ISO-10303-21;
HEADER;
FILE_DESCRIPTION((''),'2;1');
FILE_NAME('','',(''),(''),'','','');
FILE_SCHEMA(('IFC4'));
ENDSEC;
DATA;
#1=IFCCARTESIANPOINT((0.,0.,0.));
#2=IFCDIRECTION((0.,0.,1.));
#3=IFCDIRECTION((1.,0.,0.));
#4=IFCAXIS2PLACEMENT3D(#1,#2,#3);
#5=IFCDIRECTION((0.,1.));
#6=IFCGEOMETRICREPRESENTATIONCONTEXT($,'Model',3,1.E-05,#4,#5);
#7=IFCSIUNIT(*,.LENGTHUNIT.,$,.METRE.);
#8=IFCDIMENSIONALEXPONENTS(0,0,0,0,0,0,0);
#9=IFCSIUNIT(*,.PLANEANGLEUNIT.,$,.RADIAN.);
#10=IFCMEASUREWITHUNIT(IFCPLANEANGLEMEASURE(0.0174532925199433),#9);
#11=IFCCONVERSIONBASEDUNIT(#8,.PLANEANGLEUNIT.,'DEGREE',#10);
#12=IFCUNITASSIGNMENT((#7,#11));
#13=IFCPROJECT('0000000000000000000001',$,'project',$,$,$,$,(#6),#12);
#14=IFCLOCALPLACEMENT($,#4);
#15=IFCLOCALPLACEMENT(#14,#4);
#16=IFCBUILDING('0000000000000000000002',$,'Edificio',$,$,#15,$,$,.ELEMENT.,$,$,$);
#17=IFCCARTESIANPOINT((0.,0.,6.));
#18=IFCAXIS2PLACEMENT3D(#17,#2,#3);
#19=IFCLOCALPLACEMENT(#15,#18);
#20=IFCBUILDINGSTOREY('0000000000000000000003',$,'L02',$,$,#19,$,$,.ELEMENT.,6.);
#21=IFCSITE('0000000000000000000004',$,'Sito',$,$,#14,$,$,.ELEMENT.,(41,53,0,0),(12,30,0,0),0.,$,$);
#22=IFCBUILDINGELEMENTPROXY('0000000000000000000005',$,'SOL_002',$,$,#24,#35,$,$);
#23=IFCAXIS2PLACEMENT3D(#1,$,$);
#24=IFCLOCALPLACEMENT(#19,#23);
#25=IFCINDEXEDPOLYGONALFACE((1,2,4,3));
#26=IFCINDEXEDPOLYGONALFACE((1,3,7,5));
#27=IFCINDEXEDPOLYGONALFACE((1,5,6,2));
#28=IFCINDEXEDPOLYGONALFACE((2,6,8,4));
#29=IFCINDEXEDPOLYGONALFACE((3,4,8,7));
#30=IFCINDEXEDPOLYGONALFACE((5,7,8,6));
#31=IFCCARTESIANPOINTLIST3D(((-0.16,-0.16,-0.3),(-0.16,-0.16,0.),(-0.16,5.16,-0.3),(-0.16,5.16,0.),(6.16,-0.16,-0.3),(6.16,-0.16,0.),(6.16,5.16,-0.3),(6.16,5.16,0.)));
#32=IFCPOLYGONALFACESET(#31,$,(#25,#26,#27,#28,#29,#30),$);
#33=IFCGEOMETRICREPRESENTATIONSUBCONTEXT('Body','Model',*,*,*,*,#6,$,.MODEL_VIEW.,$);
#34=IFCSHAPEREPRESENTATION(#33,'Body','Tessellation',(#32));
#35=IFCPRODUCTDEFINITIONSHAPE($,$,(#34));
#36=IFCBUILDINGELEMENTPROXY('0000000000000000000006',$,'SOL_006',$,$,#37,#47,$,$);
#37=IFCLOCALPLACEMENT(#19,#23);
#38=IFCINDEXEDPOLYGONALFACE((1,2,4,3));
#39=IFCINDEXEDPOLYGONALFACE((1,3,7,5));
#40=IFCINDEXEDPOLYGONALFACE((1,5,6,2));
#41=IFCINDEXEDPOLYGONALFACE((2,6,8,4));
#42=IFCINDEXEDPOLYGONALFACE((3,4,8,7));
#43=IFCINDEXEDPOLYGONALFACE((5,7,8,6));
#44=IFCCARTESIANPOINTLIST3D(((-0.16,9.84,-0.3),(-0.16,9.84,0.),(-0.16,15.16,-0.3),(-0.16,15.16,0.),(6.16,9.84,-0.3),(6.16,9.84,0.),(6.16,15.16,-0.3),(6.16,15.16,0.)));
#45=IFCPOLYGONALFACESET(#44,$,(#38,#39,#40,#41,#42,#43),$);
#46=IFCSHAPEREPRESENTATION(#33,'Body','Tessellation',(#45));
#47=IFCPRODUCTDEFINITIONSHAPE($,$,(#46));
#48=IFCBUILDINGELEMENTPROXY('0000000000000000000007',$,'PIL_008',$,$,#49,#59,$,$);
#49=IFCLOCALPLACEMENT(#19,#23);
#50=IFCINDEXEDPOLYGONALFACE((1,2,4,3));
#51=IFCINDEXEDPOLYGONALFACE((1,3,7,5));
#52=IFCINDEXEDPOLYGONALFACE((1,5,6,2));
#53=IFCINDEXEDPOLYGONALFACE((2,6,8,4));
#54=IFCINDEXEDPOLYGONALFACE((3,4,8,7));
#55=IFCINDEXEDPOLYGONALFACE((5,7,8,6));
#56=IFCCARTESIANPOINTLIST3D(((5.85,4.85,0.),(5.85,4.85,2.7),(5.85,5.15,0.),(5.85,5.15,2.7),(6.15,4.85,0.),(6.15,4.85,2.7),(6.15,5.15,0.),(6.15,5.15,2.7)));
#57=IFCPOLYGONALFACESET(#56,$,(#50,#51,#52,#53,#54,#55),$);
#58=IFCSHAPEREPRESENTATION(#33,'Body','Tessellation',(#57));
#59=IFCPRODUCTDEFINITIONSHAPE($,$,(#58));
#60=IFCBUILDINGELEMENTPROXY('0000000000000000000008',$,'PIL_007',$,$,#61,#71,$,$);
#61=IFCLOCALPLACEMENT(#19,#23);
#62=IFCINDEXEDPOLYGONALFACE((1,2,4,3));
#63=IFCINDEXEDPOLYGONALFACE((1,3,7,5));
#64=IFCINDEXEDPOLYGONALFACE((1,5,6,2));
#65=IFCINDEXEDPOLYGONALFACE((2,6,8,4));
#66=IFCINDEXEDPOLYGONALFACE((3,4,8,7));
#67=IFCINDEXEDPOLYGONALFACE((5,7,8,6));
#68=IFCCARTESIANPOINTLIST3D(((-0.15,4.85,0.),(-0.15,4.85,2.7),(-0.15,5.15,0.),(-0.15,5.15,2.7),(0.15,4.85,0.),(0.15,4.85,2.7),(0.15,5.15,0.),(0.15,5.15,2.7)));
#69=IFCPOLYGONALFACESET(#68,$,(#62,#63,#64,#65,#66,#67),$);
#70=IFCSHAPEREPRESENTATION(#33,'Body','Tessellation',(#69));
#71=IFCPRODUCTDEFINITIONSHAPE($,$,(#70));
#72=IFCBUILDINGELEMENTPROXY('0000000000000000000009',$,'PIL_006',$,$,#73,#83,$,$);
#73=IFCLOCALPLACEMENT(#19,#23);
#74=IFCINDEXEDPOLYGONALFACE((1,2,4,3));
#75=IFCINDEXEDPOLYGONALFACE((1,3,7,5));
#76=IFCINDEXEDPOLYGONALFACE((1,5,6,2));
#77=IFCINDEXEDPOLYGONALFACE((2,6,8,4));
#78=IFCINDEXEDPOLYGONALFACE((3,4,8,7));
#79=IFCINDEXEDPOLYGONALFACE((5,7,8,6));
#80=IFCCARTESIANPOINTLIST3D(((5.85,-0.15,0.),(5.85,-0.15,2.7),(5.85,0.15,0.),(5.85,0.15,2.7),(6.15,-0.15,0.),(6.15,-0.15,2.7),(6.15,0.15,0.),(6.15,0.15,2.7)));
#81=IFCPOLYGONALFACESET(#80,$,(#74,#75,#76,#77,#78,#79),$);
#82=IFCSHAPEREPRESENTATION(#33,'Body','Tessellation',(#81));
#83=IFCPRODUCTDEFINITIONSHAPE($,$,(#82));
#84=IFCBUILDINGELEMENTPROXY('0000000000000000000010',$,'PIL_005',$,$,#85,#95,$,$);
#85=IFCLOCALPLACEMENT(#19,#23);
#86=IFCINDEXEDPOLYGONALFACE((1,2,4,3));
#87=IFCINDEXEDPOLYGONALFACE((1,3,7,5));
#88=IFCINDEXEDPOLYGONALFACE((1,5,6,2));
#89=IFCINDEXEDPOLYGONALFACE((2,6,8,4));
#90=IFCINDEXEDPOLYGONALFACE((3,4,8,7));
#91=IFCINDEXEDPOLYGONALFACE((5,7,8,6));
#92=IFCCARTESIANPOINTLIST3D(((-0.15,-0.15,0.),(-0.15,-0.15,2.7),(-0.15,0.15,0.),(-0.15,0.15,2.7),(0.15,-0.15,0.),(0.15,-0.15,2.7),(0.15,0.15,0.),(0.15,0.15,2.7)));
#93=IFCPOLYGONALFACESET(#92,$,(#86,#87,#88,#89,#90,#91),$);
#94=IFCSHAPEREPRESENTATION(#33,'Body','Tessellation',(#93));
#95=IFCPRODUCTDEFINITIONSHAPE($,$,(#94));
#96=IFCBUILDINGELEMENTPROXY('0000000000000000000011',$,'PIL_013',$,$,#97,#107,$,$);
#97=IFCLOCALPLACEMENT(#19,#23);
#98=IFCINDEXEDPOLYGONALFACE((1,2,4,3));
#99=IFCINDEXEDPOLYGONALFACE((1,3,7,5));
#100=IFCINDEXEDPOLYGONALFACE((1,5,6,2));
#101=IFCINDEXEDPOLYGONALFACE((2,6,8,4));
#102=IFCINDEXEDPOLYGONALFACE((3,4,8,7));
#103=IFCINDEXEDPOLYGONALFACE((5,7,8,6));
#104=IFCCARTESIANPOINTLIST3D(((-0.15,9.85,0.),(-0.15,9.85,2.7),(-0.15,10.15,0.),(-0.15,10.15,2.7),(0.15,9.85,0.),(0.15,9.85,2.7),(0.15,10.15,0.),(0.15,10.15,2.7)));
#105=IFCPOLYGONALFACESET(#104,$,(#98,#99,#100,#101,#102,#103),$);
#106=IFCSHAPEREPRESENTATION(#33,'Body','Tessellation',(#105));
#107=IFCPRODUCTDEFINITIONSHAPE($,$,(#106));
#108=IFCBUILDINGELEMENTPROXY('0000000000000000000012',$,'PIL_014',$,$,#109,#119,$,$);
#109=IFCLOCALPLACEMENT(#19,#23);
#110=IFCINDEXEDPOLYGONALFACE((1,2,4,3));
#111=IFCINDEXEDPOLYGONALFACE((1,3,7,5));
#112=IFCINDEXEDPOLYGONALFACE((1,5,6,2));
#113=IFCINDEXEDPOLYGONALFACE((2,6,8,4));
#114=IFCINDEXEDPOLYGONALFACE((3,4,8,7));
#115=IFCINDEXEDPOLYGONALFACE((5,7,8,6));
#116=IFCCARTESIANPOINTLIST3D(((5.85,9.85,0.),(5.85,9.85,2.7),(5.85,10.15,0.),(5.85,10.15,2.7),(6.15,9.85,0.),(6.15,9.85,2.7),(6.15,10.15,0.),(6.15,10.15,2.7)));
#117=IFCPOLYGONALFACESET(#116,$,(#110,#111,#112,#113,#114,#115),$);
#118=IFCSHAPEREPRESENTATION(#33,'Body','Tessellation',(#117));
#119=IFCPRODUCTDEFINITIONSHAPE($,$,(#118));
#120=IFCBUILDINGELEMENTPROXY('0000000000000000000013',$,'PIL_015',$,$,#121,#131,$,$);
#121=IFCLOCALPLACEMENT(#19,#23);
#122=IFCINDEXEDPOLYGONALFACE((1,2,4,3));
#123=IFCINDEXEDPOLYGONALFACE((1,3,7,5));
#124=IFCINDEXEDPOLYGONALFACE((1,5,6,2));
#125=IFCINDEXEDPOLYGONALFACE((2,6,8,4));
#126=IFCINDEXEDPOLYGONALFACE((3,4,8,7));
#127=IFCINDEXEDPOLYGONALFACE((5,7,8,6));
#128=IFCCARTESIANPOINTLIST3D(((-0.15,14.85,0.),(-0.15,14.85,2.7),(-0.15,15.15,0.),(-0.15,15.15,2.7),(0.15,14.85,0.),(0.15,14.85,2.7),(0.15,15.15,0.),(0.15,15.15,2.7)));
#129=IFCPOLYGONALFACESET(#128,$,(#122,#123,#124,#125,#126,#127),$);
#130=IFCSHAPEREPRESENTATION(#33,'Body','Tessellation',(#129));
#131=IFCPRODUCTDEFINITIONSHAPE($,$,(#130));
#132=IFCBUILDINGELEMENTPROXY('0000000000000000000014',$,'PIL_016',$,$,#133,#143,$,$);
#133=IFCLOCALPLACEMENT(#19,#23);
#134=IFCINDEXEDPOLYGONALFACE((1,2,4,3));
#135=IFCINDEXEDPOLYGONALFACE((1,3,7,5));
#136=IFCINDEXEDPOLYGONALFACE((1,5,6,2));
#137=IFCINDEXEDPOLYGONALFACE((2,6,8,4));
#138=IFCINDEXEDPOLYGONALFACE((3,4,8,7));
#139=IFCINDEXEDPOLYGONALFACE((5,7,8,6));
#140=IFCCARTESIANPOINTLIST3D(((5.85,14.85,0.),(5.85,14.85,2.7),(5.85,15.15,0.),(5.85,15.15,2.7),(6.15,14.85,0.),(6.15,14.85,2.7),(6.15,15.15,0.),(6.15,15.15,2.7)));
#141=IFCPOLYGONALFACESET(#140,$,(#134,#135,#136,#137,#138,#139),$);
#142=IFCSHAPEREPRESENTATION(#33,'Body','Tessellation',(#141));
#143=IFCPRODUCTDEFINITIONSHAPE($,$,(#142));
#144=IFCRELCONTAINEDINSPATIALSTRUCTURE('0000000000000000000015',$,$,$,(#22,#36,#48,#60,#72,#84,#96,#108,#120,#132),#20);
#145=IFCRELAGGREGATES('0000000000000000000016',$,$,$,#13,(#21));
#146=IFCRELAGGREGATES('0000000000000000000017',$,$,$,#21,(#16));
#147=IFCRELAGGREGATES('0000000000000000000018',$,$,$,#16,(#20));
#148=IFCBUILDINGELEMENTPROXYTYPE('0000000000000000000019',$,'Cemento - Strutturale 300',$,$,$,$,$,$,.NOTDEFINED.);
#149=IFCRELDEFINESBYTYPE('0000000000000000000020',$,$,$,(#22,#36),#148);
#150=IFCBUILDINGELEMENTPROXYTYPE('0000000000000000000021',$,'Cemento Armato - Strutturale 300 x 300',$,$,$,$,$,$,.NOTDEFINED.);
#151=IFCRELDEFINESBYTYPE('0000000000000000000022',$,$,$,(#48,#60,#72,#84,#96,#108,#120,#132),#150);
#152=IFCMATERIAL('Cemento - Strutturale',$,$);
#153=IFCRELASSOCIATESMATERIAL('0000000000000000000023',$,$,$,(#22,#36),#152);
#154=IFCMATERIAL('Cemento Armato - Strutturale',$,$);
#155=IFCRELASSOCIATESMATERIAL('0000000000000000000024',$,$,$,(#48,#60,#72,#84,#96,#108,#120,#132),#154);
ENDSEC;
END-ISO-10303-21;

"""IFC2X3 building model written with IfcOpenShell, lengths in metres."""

from ifc_helpers import new_model, entity, si_unit, converted_unit, direction, frame, origin_with_axes, origin_2d_with_axis, place, context, subcontext, project, spatial, polyline, rectangle, outline, extrude, material, type_object, element, save


model = new_model("IFC2X3")

# Units and contexts
model_context = context("Model", 3, precision=1e-05, world=origin_with_axes(), true_north=direction((0.0, 1.0)))
body_context = subcontext(model_context, "Body", "Model", "MODEL_VIEW")
ifc_project = project(units=[si_unit("LENGTHUNIT", "METRE"), converted_unit("PLANEANGLEUNIT", "DEGREE", entity("IfcPlaneAngleMeasure", 0.0174532925199433), si_unit("PLANEANGLEUNIT", "RADIAN"), dimensions=[0, 0, 0, 0, 0, 0, 0])], contexts=[model_context])

# Site, building, storey
site_placement = place(None, origin_with_axes())
site = spatial("IfcSite", under=ifc_project, at=site_placement, Name="Sito", CompositionType="ELEMENT", RefLatitude=(41, 53, 0, 0), RefLongitude=(12, 30, 0, 0), RefElevation=0.0)
building_placement = place(site_placement, origin_with_axes())
building = spatial("IfcBuilding", under=site, at=building_placement, Name="Edificio", CompositionType="ELEMENT")
storey_placement = place(building_placement, frame((0.0, 0.0, 6.0), z_axis=(0.0, 0.0, 1.0), x_axis=(1.0, 0.0, 0.0)))
storey = spatial("IfcBuildingStorey", under=building, at=storey_placement, Name="L02", CompositionType="ELEMENT", Elevation=6.0)

# Building element proxies
ifc_material_1 = material(Name="Cemento - Strutturale")
building_element_proxy_type_1 = type_object("IfcBuildingElementProxyType", Name="Cemento - Strutturale 300", PredefinedType="NOTDEFINED")
for number, where, z_axis, x_axis, name in (
    (1, (-0.16, -0.16, 0.0), (0.0, 0.0, 1.0), (1.0, 0.0, 0.0), "SOL_002"),
    (2, (-0.16, 9.84, 0.0), (0.0, 0.0, 1.0), (1.0, 0.0, 0.0), "SOL_006"),
):
    element("IfcBuildingElementProxy", number, at=place(storey_placement, frame(where, z_axis=z_axis, x_axis=x_axis)), inside=storey, type_object=building_element_proxy_type_1, material=ifc_material_1, Name=name, context=body_context, shape_type="SweptSolid", body=[
        extrude(outline(polyline([(0.0, 0.0), (6.32, 0.0), (6.32, 5.32), (0.0, 5.32), (0.0, 0.0)])), frame((0.0, 0.0, -0.3), z_axis=(0.0, 0.0, 1.0), x_axis=(1.0, 0.0, 0.0)), (0.0, 0.0, 1.0), 0.3),
    ])
ifc_material_2 = material(Name="Cemento Armato - Strutturale")
building_element_proxy_type_2 = type_object("IfcBuildingElementProxyType", Name="Cemento Armato - Strutturale 300 x 300", PredefinedType="NOTDEFINED")
for number, where, z_axis, x_axis, name in (
    (3, (6.0, 5.0, 0.0), (0.0, 0.0, 1.0), (1.0, 0.0, 0.0), "PIL_008"),
    (4, (0.0, 5.0, 0.0), (0.0, 0.0, 1.0), (1.0, 0.0, 0.0), "PIL_007"),
    (5, (6.0, 0.0, 0.0), (0.0, 0.0, 1.0), (1.0, 0.0, 0.0), "PIL_006"),
    (6, (0.0, 0.0, 0.0), (0.0, 0.0, 1.0), (1.0, 0.0, 0.0), "PIL_005"),
    (7, (0.0, 10.0, 0.0), (0.0, 0.0, 1.0), (1.0, 0.0, 0.0), "PIL_013"),
    (8, (6.0, 10.0, 0.0), (0.0, 0.0, 1.0), (1.0, 0.0, 0.0), "PIL_014"),
    (9, (0.0, 15.0, 0.0), (0.0, 0.0, 1.0), (1.0, 0.0, 0.0), "PIL_015"),
    (10, (6.0, 15.0, 0.0), (0.0, 0.0, 1.0), (1.0, 0.0, 0.0), "PIL_016"),
):
    element("IfcBuildingElementProxy", number, at=place(storey_placement, frame(where, z_axis=z_axis, x_axis=x_axis)), inside=storey, type_object=building_element_proxy_type_2, material=ifc_material_2, Name=name, context=body_context, shape_type="SweptSolid", body=[
        extrude(rectangle(XDim=0.3, YDim=0.3, at=origin_2d_with_axis()), origin_with_axes(), (0.0, 0.0, 1.0), 2.7),
    ])

save(model, "model.ifc")
